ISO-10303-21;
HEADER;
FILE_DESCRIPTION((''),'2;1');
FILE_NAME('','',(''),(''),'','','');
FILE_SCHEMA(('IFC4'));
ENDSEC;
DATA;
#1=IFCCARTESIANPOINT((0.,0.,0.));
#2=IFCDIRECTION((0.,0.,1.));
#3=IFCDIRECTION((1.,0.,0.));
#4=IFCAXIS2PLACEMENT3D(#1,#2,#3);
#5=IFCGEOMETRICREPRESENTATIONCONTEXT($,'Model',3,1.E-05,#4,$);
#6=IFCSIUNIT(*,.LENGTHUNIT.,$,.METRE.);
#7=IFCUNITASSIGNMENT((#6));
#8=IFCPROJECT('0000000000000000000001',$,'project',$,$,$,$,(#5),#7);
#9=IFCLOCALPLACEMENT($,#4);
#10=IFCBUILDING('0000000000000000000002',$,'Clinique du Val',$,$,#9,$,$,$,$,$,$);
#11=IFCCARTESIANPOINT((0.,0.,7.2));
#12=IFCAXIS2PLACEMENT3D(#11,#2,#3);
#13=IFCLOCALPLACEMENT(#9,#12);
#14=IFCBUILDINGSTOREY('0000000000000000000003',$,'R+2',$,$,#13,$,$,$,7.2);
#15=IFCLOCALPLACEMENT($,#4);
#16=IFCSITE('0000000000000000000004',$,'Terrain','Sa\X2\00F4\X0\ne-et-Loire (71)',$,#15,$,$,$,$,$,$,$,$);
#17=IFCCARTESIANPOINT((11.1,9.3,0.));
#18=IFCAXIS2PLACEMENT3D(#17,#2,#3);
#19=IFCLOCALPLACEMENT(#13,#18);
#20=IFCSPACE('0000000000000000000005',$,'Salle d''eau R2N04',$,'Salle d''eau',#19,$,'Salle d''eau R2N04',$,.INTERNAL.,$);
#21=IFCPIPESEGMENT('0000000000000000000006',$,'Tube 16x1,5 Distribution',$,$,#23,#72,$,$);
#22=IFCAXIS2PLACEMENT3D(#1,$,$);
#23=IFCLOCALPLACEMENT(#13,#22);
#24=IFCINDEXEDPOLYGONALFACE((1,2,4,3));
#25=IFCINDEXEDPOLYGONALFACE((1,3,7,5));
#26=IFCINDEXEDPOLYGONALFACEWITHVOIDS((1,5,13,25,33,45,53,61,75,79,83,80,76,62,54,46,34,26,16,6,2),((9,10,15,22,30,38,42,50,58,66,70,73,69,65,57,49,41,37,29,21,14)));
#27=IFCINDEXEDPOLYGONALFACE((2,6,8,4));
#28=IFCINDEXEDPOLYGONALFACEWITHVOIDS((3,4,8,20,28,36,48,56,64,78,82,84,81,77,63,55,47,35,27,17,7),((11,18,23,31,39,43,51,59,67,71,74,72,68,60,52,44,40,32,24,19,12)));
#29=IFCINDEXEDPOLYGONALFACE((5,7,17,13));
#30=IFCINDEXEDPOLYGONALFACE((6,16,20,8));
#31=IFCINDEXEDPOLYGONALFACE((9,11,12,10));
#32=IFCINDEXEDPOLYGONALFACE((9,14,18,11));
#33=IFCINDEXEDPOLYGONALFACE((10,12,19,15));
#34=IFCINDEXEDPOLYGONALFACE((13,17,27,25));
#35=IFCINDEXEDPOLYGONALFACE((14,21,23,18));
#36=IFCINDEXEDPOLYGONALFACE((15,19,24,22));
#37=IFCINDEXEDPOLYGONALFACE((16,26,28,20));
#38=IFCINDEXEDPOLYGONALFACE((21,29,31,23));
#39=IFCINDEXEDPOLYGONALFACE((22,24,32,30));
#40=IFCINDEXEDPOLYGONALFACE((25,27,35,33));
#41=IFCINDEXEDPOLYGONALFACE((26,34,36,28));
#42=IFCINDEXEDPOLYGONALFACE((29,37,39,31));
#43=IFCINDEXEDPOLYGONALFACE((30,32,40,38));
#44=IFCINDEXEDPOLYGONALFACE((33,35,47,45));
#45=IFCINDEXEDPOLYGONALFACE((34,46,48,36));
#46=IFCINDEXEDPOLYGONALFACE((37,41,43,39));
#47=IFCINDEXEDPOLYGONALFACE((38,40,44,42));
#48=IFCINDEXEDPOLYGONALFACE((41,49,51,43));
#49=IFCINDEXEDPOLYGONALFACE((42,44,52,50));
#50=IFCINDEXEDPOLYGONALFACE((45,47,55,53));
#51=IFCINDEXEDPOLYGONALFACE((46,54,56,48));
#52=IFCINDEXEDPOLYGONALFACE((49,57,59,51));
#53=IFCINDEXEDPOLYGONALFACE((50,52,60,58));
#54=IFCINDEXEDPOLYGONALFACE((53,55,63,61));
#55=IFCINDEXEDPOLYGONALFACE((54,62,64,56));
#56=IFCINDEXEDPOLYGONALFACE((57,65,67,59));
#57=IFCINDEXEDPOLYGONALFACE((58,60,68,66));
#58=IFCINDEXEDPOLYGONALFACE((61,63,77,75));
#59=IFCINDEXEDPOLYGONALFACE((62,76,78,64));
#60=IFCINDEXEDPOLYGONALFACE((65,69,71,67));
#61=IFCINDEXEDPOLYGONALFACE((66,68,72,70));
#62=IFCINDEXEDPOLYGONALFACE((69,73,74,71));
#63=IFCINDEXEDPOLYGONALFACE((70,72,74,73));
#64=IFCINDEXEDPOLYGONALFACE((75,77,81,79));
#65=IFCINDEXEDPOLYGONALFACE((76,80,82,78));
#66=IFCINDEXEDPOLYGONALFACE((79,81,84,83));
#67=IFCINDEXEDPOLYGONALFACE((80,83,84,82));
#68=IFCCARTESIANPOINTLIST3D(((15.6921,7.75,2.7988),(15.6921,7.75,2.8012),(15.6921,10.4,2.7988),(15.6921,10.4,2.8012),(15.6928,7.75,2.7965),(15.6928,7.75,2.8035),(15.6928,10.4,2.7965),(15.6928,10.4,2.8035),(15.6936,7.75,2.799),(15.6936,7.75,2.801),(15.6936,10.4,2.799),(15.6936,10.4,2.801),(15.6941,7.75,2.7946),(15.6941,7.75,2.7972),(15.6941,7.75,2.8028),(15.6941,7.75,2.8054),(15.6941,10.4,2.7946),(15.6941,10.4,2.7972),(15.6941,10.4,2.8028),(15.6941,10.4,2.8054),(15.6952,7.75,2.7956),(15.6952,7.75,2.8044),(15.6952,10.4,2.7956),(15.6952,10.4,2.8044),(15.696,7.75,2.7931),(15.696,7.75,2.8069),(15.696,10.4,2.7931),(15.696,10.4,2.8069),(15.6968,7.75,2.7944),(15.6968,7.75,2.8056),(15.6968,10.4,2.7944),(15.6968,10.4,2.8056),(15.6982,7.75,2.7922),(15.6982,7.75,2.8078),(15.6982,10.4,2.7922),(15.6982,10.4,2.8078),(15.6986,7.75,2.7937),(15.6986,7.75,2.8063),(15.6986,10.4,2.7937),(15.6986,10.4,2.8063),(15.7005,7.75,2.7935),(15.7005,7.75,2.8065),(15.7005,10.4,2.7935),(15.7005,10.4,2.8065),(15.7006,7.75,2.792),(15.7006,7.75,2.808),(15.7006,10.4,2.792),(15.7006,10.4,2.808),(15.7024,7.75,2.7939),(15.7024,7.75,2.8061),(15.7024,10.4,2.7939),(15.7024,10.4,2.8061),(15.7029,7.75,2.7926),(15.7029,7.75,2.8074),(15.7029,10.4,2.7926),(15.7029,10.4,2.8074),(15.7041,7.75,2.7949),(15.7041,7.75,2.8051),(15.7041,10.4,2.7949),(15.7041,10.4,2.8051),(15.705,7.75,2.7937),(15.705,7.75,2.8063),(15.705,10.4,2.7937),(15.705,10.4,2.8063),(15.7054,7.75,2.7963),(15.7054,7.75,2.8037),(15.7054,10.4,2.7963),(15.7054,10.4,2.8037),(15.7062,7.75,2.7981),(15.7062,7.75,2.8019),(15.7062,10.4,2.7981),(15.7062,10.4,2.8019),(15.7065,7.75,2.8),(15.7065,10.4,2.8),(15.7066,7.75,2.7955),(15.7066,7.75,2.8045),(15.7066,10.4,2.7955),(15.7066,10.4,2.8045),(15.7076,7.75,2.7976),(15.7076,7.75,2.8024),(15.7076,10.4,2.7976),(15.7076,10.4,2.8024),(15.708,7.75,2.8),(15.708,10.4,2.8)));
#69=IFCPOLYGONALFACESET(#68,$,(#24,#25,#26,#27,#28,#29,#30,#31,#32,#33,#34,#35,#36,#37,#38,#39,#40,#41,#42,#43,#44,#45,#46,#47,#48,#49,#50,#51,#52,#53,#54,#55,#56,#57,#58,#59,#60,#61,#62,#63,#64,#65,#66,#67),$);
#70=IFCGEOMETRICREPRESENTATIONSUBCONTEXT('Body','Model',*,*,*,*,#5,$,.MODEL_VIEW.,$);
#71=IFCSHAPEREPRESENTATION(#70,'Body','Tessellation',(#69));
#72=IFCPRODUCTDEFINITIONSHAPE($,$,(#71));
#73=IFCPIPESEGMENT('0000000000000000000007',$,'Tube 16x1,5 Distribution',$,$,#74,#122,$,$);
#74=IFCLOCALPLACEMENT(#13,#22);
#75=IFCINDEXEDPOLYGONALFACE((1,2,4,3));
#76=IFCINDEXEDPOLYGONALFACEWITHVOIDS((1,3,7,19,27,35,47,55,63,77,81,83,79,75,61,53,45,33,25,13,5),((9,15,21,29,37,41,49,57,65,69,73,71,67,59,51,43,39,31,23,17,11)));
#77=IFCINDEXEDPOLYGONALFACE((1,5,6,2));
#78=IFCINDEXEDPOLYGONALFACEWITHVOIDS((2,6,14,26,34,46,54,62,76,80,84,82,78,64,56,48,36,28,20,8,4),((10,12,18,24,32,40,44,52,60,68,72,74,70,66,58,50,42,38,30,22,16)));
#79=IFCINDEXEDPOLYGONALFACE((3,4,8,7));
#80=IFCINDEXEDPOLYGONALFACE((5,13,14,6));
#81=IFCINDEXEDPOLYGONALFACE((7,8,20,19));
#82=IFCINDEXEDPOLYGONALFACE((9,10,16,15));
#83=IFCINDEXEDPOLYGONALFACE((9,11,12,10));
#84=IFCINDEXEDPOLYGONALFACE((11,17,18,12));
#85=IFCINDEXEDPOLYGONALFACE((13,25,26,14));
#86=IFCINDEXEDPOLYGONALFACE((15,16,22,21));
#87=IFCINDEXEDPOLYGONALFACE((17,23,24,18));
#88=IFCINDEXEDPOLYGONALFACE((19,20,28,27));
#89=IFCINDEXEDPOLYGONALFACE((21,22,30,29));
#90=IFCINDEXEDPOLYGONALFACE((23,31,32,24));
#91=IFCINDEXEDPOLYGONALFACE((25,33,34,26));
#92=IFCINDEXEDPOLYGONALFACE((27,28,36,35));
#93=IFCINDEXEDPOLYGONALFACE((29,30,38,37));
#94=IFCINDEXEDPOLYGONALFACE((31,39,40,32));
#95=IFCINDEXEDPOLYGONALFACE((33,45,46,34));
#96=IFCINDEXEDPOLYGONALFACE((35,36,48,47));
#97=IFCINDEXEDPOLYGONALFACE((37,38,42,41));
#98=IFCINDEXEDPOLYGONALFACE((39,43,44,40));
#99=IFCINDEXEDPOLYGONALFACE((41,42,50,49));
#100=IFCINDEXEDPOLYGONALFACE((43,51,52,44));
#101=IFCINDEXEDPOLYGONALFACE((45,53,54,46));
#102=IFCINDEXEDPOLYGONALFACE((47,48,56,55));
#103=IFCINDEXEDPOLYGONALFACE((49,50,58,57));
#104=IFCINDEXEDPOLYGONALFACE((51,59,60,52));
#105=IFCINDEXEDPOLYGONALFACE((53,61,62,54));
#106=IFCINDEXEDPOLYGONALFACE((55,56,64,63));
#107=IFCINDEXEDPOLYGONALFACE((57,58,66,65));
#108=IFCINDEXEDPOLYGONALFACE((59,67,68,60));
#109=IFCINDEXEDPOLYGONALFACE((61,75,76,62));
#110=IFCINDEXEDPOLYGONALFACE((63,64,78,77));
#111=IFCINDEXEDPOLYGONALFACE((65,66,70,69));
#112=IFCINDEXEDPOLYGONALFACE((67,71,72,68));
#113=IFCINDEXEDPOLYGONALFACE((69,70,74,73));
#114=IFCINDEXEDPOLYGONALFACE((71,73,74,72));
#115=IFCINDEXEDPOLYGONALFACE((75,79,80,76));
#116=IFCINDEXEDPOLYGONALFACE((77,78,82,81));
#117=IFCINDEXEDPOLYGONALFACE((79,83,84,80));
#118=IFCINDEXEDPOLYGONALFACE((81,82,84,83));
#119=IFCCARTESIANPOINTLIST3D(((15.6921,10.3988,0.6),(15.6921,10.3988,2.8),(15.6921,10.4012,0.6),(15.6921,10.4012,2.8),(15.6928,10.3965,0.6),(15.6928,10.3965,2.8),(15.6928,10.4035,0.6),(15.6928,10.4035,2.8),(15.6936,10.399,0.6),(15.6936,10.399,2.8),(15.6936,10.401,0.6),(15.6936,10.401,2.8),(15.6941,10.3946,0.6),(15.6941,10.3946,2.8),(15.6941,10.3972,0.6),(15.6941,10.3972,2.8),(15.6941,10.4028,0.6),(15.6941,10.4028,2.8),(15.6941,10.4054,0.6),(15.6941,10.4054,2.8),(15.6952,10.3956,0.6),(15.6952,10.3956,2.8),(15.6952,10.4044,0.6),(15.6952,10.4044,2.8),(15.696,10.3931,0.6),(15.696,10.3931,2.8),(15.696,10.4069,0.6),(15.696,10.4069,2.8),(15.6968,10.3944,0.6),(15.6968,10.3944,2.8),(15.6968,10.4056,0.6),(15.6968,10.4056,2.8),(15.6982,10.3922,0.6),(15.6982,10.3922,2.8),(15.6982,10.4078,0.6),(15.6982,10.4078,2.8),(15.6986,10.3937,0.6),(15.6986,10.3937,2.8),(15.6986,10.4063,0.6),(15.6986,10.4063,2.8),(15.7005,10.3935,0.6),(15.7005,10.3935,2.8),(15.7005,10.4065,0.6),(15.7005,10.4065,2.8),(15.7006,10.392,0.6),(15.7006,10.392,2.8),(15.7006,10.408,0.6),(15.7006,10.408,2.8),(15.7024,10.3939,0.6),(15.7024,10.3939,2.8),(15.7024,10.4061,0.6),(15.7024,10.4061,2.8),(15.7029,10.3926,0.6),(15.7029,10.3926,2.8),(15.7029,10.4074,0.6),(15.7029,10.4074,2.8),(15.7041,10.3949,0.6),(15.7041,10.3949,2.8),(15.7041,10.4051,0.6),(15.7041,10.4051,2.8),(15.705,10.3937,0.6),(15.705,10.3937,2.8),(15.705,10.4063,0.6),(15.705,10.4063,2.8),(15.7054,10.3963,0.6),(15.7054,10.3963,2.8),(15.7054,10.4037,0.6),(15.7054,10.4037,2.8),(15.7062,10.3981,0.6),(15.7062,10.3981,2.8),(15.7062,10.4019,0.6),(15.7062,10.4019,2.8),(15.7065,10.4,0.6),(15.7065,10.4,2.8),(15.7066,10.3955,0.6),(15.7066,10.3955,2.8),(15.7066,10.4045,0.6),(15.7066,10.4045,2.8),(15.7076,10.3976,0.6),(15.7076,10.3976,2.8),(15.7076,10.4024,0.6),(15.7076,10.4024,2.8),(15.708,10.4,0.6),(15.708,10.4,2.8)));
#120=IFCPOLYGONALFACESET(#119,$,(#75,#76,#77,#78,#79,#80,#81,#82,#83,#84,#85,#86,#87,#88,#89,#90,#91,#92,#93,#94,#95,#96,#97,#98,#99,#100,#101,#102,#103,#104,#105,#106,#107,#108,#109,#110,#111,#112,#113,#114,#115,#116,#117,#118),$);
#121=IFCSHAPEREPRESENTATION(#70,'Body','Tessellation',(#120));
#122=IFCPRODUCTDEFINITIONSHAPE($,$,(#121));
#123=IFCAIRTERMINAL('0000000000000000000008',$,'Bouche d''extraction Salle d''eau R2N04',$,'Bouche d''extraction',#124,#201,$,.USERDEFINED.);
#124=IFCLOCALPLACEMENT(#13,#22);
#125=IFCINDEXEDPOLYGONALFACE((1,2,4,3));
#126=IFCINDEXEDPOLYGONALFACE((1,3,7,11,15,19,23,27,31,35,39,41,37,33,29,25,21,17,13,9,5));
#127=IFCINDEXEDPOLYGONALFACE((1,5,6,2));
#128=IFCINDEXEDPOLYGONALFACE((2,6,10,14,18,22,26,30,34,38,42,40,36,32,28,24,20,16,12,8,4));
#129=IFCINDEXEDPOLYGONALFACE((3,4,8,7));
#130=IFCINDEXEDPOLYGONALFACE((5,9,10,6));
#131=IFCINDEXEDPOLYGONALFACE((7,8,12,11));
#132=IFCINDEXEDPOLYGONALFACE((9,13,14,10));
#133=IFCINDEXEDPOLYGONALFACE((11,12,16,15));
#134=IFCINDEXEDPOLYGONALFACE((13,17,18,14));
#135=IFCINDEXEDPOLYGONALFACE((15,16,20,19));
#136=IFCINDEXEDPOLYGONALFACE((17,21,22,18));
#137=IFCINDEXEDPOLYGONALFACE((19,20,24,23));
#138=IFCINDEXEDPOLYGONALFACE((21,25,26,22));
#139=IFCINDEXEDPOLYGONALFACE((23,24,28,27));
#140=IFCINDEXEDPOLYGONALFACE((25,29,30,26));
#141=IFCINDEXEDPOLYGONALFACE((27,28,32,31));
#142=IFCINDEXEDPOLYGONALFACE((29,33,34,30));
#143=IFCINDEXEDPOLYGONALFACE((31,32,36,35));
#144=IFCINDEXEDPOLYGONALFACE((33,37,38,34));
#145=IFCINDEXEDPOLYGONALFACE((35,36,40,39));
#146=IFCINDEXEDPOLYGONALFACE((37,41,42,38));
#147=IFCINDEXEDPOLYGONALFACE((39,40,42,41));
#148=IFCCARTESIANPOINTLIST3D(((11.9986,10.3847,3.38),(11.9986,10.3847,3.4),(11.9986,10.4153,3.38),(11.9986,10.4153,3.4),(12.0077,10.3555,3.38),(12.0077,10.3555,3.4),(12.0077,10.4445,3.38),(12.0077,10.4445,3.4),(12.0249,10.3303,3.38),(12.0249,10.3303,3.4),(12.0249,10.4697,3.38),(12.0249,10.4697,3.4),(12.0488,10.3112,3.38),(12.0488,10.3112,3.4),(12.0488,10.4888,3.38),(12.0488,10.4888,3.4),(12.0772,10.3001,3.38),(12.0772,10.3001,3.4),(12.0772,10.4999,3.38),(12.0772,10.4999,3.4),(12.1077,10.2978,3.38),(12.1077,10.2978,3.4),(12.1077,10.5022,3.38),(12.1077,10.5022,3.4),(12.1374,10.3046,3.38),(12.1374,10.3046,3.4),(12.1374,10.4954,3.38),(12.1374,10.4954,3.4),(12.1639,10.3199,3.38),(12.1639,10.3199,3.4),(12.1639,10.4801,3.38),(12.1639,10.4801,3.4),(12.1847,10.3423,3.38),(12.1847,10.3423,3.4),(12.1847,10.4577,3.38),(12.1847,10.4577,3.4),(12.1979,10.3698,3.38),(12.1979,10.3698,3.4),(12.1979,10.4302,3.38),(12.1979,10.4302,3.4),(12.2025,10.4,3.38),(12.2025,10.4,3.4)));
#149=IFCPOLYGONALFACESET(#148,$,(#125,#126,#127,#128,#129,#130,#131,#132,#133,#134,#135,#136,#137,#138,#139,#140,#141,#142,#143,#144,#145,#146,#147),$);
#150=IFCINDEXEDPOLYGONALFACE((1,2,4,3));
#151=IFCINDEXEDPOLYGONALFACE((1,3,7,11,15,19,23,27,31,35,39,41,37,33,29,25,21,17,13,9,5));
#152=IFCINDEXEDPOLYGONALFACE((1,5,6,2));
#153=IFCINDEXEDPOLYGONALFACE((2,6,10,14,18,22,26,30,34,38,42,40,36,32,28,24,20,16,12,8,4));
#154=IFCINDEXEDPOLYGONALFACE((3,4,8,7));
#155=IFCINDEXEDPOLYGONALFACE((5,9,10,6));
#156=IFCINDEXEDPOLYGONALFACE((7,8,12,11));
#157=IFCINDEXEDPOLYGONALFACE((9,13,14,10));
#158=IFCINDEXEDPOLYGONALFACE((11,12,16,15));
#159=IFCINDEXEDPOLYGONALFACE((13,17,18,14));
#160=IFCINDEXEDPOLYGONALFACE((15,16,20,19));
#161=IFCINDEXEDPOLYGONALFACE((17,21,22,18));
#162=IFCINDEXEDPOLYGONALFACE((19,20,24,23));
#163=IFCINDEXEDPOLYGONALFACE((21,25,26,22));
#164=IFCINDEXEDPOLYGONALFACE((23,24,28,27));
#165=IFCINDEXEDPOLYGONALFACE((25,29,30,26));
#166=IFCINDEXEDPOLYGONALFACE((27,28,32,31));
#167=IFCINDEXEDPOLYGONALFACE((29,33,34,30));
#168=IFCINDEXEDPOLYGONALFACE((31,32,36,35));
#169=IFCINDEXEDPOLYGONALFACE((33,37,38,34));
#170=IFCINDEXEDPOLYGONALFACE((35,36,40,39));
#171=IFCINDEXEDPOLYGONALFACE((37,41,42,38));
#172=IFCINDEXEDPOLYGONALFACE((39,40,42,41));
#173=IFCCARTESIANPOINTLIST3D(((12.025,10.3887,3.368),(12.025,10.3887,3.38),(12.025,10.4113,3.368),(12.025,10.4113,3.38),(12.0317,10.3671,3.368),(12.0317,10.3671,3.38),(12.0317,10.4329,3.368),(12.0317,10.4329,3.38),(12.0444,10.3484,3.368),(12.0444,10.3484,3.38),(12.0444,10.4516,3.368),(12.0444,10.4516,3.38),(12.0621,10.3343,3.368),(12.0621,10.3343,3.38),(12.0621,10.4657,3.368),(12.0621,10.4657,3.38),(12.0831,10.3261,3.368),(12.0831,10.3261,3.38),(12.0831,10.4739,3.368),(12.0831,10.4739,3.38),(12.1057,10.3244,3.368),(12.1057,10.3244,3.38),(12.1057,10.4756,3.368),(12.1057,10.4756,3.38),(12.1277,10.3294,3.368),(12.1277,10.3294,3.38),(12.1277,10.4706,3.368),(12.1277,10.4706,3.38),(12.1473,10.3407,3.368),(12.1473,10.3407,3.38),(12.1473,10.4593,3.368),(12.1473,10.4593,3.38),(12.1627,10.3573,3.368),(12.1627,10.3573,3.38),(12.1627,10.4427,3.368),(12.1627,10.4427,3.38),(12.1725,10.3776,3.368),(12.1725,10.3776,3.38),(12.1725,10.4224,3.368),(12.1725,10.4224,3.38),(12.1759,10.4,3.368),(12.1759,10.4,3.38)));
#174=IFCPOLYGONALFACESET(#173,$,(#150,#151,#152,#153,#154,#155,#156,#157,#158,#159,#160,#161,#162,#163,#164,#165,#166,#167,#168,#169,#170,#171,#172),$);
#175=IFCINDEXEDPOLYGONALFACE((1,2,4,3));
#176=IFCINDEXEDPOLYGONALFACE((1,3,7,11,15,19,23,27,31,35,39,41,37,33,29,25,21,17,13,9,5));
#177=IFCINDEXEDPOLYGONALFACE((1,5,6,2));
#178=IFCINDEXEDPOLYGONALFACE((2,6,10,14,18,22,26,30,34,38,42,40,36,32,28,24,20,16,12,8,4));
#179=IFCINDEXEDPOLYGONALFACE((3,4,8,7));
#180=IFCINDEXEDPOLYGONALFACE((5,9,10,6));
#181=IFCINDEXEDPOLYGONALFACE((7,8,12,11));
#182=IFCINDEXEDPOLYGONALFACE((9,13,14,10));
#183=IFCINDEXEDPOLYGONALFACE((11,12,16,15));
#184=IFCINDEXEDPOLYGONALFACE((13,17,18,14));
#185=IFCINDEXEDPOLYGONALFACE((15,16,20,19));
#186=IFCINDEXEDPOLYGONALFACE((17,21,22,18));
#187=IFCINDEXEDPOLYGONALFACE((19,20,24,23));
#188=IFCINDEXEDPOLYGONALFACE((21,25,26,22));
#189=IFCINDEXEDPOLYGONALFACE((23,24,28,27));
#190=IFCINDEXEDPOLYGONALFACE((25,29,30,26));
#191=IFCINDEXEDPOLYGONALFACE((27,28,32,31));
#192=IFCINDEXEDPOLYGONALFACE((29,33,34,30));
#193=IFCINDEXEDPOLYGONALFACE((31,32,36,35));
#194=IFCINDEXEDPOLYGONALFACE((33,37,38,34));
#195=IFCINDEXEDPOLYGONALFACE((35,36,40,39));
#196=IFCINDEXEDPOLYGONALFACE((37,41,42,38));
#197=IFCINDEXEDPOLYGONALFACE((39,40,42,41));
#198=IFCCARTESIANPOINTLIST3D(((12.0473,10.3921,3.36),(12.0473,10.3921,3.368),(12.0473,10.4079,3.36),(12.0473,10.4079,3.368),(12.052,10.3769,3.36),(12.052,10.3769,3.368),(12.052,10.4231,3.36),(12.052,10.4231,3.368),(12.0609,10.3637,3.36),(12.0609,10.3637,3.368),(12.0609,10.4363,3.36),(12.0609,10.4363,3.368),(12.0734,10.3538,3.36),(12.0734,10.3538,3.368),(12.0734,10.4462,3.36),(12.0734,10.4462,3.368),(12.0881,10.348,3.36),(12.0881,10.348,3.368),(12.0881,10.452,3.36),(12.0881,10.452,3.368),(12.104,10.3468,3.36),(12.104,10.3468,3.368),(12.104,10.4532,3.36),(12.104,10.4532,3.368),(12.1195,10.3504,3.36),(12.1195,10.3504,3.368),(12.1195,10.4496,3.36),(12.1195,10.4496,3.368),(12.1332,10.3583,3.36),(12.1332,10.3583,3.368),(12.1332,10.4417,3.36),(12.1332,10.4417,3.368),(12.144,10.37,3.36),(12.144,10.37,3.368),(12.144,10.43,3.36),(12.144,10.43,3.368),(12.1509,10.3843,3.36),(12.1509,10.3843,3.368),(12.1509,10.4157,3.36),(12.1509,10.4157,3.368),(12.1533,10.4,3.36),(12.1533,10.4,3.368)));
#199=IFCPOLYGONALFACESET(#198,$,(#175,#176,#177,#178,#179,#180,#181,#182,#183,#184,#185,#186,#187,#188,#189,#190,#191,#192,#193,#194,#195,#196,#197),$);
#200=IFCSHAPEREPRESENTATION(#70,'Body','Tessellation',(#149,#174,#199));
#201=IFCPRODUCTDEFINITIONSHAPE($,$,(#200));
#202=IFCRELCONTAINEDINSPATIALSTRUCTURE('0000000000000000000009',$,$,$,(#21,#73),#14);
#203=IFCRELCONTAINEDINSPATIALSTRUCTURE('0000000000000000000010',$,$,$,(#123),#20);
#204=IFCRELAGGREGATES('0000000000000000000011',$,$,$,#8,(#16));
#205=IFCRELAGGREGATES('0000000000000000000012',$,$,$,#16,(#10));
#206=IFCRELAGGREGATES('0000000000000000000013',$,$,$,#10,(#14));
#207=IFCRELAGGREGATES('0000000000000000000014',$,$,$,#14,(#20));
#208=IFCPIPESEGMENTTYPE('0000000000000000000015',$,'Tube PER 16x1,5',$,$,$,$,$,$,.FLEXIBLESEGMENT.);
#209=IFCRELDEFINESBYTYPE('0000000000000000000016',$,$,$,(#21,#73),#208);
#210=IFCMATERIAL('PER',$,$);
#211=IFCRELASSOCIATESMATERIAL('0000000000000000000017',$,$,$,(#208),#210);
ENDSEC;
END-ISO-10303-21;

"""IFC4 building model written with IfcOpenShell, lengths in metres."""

from ifc_helpers import new_model, si_unit, frame, origin_with_axes, place, context, subcontext, project, spatial, circle, hollow_circle, extrude, material, type_object, element, save


model = new_model("IFC4")

# Units and contexts
model_context = context("Model", 3, precision=1e-05, world=origin_with_axes())
body_context = subcontext(model_context, "Body", "Model", "MODEL_VIEW")
ifc_project = project(units=[si_unit("LENGTHUNIT", "METRE")], contexts=[model_context])

# Site, building, storey
site_placement = place(None, origin_with_axes())
site = spatial("IfcSite", under=ifc_project, at=site_placement, Name="Terrain", Description="Saône-et-Loire (71)")
building_placement = place(None, origin_with_axes())
building = spatial("IfcBuilding", under=site, at=building_placement, Name="Clinique du Val")
storey_placement = place(building_placement, frame((0.0, 0.0, 7.2), z_axis=(0.0, 0.0, 1.0), x_axis=(1.0, 0.0, 0.0)))
storey = spatial("IfcBuildingStorey", under=building, at=storey_placement, Name="R+2", Elevation=7.2)

# Pipe segments
ifc_material_1 = material(Name="PER")
pipe_segment_type_1 = type_object("IfcPipeSegmentType", Name="Tube PER 16x1,5", PredefinedType="FLEXIBLESEGMENT", material=ifc_material_1)
pipe_segment_1_placement = place(storey_placement, frame((15.7, 7.75, 2.8), z_axis=(0.0, 1.0, 0.0), x_axis=(1.0, 0.0, 0.0)))
element("IfcPipeSegment", 1, at=pipe_segment_1_placement, inside=storey, type_object=pipe_segment_type_1, Name="Tube 16x1,5 Distribution", context=body_context, shape_type="SweptSolid", body=[
    extrude(hollow_circle(Radius=0.008, WallThickness=0.0015), origin_with_axes(), (0.0, 0.0, 1.0), 2.65),
])
pipe_segment_2_placement = place(storey_placement, frame((15.7, 10.4, 2.8), z_axis=(0.0, 0.0, -1.0), x_axis=(1.0, 0.0, 0.0)))
element("IfcPipeSegment", 2, at=pipe_segment_2_placement, inside=storey, type_object=pipe_segment_type_1, Name="Tube 16x1,5 Distribution", context=body_context, shape_type="SweptSolid", body=[
    extrude(hollow_circle(Radius=0.008, WallThickness=0.0015), origin_with_axes(), (0.0, 0.0, 1.0), 2.2),
])

# Shared definitions
space_1_placement = place(storey_placement, frame((11.1, 9.3, 0.0), z_axis=(0.0, 0.0, 1.0), x_axis=(1.0, 0.0, 0.0)))
space_1 = spatial("IfcSpace", under=storey, at=space_1_placement, Name="Salle d'eau R2N04", ObjectType="Salle d'eau", LongName="Salle d'eau R2N04", PredefinedType="INTERNAL")

# Air terminal
air_terminal_placement = place(space_1_placement, frame((1.0, 1.1, 3.36), z_axis=(0.0, 0.0, 1.0), x_axis=(1.0, 0.0, 0.0)))
element("IfcAirTerminal", 3, at=air_terminal_placement, inside=space_1, Name="Bouche d'extraction Salle d'eau R2N04", ObjectType="Bouche d'extraction", PredefinedType="USERDEFINED", context=body_context, shape_type="SweptSolid", body=[
    extrude(circle(Radius=0.1025), frame((0.0, 0.0, 0.02), z_axis=(0.0, 0.0, 1.0), x_axis=(1.0, 0.0, 0.0)), (0.0, 0.0, 1.0), 0.02),
    extrude(circle(Radius=0.0759), frame((0.0, 0.0, 0.008), z_axis=(0.0, 0.0, 1.0), x_axis=(1.0, 0.0, 0.0)), (0.0, 0.0, 1.0), 0.012),
    extrude(circle(Radius=0.0533), origin_with_axes(), (0.0, 0.0, 1.0), 0.008),
])

save(model, "model.ifc")
